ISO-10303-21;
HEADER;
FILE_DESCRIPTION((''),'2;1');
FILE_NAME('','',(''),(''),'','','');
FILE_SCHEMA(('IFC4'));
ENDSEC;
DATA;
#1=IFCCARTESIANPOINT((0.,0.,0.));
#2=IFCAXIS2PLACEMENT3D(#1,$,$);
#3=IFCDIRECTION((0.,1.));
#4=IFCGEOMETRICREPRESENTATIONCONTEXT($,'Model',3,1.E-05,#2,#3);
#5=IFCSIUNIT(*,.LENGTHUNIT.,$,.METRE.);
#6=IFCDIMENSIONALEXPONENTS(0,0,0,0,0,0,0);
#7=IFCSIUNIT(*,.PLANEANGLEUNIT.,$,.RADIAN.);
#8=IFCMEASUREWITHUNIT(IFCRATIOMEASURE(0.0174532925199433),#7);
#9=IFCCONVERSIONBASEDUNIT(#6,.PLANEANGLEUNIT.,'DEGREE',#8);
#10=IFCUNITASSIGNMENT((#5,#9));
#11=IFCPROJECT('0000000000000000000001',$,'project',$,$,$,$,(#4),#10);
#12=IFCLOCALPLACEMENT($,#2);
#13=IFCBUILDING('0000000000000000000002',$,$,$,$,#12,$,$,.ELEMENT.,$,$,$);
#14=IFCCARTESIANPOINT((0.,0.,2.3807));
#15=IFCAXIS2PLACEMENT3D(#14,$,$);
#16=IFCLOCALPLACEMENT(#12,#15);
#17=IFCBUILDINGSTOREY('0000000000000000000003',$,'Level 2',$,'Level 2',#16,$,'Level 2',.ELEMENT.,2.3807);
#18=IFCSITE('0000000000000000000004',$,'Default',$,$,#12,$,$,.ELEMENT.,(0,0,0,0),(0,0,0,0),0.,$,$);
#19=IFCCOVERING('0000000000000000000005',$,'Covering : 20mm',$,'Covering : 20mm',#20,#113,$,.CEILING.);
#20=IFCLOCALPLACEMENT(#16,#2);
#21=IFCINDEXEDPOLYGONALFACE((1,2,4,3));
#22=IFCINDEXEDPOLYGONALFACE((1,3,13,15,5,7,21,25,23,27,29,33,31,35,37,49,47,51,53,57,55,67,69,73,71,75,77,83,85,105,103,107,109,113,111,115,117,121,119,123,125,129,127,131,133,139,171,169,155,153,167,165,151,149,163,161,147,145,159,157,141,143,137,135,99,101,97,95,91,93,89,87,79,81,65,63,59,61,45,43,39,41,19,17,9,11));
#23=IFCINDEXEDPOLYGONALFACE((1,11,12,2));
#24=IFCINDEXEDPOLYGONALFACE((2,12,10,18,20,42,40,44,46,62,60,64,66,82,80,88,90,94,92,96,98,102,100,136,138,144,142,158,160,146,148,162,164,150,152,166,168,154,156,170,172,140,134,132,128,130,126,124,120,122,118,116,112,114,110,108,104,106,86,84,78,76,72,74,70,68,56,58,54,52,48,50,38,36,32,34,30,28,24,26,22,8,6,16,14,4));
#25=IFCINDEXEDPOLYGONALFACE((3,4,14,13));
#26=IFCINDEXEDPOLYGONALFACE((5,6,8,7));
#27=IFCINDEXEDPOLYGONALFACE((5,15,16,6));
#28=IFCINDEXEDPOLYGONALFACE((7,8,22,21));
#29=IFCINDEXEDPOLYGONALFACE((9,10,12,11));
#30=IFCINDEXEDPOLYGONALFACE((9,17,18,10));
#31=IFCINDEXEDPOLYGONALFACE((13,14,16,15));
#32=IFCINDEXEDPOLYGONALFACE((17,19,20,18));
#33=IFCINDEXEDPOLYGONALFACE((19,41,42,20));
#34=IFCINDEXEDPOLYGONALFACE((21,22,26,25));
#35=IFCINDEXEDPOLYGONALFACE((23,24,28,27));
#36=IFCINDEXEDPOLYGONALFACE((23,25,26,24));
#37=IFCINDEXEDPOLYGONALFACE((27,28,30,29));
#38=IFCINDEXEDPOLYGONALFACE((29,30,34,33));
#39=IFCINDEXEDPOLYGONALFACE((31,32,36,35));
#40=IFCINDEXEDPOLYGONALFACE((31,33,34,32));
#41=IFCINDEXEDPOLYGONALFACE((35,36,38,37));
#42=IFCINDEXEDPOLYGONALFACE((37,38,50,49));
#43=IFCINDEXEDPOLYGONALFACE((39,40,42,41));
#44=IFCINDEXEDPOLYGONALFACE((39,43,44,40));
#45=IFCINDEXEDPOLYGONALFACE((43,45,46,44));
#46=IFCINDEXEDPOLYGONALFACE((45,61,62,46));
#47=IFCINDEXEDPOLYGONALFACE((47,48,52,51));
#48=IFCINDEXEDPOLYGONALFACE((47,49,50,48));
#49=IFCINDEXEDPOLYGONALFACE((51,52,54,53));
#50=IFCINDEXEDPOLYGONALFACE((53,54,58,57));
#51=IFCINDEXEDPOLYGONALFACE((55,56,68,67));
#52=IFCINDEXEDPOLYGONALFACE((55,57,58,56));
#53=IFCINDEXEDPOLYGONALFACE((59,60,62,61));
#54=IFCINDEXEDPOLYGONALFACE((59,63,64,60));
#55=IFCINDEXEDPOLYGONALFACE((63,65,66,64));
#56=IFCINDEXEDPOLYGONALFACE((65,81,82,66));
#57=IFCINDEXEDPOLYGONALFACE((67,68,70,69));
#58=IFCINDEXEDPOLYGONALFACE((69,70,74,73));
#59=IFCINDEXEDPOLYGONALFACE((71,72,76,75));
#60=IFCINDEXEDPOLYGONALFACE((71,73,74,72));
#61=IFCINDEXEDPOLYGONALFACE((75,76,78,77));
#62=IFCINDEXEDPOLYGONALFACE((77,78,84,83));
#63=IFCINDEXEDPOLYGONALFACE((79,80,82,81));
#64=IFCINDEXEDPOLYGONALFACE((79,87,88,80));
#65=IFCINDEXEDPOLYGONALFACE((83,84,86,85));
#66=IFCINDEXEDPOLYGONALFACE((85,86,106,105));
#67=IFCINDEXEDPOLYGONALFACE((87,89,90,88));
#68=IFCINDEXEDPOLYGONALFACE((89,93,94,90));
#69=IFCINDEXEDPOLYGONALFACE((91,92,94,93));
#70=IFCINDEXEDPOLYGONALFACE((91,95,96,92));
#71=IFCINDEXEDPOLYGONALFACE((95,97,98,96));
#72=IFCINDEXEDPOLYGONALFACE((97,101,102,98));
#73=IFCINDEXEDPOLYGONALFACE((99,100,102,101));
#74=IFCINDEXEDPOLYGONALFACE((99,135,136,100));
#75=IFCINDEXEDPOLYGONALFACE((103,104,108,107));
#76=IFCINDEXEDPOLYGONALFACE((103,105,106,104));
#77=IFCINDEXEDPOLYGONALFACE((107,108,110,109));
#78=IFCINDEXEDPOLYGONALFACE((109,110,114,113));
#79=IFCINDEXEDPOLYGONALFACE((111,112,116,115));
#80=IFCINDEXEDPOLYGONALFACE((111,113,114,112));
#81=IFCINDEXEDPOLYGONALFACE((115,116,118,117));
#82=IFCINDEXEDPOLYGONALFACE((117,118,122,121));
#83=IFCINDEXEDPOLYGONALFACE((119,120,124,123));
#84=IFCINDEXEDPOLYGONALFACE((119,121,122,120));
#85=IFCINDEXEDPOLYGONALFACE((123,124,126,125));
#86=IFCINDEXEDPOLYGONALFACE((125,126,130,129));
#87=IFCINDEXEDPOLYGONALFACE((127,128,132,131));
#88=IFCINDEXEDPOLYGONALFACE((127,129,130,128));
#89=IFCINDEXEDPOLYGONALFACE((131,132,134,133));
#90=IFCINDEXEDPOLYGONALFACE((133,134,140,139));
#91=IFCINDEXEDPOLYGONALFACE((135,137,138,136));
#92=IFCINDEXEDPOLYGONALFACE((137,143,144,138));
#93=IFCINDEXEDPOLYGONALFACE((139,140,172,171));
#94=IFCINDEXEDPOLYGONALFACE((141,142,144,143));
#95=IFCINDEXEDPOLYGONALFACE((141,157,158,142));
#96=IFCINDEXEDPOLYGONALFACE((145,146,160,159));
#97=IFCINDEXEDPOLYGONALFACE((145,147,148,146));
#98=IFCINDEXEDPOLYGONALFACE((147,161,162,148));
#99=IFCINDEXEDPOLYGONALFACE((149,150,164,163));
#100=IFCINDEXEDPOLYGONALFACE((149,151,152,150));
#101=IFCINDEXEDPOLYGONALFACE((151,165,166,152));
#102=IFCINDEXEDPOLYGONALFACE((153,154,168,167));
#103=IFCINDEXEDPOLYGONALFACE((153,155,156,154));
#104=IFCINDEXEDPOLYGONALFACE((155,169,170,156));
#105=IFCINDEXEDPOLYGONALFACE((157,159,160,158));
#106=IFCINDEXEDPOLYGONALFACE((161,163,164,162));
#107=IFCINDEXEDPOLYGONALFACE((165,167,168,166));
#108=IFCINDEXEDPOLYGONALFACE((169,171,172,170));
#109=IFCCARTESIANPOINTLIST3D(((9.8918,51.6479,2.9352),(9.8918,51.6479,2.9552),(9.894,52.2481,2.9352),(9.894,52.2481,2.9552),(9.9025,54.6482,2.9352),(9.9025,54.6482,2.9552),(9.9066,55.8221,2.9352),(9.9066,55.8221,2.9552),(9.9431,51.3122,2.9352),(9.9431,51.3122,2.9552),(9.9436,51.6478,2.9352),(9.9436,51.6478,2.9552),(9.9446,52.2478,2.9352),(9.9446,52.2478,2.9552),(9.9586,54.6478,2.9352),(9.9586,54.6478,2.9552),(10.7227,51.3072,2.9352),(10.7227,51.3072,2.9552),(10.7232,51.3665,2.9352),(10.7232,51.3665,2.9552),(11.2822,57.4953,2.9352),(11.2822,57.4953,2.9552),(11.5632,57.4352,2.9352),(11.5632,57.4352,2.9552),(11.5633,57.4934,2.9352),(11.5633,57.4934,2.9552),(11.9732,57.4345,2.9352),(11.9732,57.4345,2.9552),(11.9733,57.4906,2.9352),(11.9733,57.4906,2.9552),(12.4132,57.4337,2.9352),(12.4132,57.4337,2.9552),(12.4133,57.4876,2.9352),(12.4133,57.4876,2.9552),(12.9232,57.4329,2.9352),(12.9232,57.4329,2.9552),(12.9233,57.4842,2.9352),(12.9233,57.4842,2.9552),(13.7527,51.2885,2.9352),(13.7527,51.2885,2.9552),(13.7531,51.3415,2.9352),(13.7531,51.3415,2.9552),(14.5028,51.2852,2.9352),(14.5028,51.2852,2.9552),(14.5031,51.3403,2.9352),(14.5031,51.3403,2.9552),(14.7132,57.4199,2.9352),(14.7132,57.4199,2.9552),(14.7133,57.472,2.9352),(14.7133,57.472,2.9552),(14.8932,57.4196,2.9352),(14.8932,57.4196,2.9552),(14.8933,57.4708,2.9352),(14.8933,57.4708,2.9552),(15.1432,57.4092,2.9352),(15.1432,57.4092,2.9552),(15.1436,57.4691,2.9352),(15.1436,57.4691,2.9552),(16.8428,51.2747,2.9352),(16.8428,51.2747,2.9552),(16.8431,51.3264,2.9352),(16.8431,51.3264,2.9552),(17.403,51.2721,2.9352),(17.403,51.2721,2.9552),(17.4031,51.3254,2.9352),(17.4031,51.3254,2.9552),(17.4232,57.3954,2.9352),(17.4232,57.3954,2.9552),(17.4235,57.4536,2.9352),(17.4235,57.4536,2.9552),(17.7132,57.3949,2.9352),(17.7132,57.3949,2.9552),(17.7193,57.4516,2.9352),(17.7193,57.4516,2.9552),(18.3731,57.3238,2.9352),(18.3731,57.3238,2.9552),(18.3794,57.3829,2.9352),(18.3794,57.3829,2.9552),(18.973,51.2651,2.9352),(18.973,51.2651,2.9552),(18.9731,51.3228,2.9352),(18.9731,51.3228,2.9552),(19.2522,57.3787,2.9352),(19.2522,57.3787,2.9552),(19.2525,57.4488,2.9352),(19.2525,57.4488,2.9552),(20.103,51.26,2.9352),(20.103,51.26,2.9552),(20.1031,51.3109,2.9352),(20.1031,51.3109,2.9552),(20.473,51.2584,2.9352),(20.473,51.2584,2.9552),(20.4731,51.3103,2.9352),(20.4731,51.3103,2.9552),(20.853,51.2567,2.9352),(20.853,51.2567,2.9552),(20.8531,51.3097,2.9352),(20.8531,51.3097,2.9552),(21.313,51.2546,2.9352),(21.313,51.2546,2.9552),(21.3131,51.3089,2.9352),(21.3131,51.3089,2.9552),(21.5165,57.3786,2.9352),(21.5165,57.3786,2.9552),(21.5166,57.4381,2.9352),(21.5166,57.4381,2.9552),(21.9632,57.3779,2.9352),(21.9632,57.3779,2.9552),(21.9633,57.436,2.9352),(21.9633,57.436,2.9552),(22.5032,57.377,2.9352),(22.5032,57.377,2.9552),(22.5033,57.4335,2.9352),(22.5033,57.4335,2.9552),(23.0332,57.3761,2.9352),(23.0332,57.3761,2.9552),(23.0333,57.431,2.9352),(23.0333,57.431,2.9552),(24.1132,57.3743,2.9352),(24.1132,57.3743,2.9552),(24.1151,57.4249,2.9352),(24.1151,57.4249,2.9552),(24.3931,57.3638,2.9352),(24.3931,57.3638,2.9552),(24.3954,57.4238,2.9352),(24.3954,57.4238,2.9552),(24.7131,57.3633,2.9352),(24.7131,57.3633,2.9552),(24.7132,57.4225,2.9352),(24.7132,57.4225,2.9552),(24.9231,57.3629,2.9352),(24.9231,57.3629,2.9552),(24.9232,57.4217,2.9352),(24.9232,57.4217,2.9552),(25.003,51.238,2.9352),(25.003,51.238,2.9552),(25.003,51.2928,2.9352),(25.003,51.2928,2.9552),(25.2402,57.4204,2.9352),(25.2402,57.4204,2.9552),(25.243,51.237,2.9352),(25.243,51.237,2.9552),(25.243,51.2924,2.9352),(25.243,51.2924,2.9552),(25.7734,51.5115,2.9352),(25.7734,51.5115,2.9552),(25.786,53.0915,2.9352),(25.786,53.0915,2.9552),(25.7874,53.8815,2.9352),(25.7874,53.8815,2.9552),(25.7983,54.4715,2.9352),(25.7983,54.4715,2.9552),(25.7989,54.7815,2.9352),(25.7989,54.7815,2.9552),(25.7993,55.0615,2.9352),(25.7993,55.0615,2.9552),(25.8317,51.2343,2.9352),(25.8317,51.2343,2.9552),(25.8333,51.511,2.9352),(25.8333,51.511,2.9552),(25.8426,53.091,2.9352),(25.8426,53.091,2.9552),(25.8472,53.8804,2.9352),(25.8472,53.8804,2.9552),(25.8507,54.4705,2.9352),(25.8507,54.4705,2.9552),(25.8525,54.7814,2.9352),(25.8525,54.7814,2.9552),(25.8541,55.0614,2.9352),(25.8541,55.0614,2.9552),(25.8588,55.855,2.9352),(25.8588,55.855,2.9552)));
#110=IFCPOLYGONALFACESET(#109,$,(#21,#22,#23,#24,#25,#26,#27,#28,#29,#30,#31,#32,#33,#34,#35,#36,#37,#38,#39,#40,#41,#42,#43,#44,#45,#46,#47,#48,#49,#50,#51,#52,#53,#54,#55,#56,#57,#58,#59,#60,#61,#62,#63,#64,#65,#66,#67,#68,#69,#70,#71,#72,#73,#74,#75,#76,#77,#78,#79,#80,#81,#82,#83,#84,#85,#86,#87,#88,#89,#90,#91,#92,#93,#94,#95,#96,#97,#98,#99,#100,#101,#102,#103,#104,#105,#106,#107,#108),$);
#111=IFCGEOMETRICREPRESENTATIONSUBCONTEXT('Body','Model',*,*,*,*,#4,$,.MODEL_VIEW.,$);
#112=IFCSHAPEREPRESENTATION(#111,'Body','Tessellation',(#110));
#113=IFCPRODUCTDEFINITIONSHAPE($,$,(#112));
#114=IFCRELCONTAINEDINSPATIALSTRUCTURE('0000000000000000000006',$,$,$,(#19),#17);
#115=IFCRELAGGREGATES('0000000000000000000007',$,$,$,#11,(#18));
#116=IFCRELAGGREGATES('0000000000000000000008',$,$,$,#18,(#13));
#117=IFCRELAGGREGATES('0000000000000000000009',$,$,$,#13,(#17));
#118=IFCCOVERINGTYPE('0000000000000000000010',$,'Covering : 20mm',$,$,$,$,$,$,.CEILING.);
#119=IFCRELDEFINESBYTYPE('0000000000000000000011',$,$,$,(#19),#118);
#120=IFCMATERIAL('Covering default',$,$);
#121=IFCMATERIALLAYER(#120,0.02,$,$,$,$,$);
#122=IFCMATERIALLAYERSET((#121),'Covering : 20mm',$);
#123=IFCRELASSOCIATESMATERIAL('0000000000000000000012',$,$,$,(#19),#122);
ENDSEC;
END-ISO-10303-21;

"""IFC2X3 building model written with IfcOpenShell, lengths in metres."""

from ifc_helpers import new_model, entity, si_unit, converted_unit, direction, frame, origin, origin_with_axes, place, context, subcontext, project, spatial, polyline, outline, extrude, material, layer, layer_set, layer_usage, type_object, element, save


model = new_model("IFC2X3")

# Units and contexts
model_context = context("Model", 3, precision=1e-05, world=origin(), true_north=direction((0.0, 1.0)))
body_context = subcontext(model_context, "Body", "Model", "MODEL_VIEW")
ifc_project = project(units=[si_unit("LENGTHUNIT", "METRE"), converted_unit("PLANEANGLEUNIT", "DEGREE", entity("IfcRatioMeasure", 0.0174532925199433), si_unit("PLANEANGLEUNIT", "RADIAN"), dimensions=[0, 0, 0, 0, 0, 0, 0])], contexts=[model_context])

# Site, building, storey
placement = place(None, origin())
site = spatial("IfcSite", under=ifc_project, at=placement, Name="Default", CompositionType="ELEMENT", RefLatitude=(0, 0, 0, 0), RefLongitude=(0, 0, 0, 0), RefElevation=0.0)
building = spatial("IfcBuilding", under=site, at=placement, CompositionType="ELEMENT")
storey_placement = place(placement, frame((0.0, 0.0, 2.3807)))
storey = spatial("IfcBuildingStorey", under=building, at=storey_placement, Name="Level 2", ObjectType="Level 2", LongName="Level 2", CompositionType="ELEMENT", Elevation=2.3807)

# Covering
ifc_material_1 = material(Name="Covering default")
ifc_layer_1 = layer(ifc_material_1, 0.02)
ifc_layer_set_1 = layer_set([ifc_layer_1], Name="Covering : 20mm")
ifc_layer_usage_1 = layer_usage(ifc_layer_set_1, "AXIS3", "POSITIVE", 0.0)
covering_type_1 = type_object("IfcCoveringType", Name="Covering : 20mm", PredefinedType="CEILING")
covering_1_placement = place(placement, frame((0.0, 0.0, 5.3159)))
element("IfcCovering", 1, at=covering_1_placement, inside=storey, type_object=covering_type_1, material=ifc_layer_usage_1, Name="Covering : 20mm", ObjectType="Covering : 20mm", PredefinedType="CEILING", context=body_context, shape_type="SweptSolid", body=[
    extrude(outline(polyline([(9.894, 52.2481), (9.9446, 52.2478), (9.9586, 54.6478), (9.9025, 54.6482), (9.9066, 55.8221), (11.2822, 57.4953), (11.5633, 57.4934), (11.5632, 57.4352), (11.9732, 57.4345), (11.9733, 57.4906), (12.4133, 57.4876), (12.4132, 57.4337), (12.9232, 57.4329), (12.9233, 57.4842), (14.7133, 57.472), (14.7132, 57.4199), (14.8932, 57.4196), (14.8933, 57.4708), (15.1436, 57.4691), (15.1432, 57.4092), (17.4232, 57.3954), (17.4235, 57.4536), (17.7193, 57.4516), (17.7132, 57.3949), (18.3731, 57.3238), (18.3794, 57.3829), (19.2522, 57.3787), (19.2525, 57.4488), (21.5166, 57.4381), (21.5165, 57.3786), (21.9632, 57.3779), (21.9633, 57.436), (22.5033, 57.4335), (22.5032, 57.377), (23.0332, 57.3761), (23.0333, 57.431), (24.1151, 57.4249), (24.1132, 57.3743), (24.3931, 57.3638), (24.3954, 57.4238), (24.7132, 57.4225), (24.7131, 57.3633), (24.9231, 57.3629), (24.9232, 57.4217), (25.2402, 57.4204), (25.8588, 55.855), (25.8541, 55.0614), (25.7993, 55.0615), (25.7989, 54.7815), (25.8525, 54.7814), (25.8507, 54.4705), (25.7983, 54.4715), (25.7874, 53.8815), (25.8472, 53.8804), (25.8426, 53.091), (25.786, 53.0915), (25.7734, 51.5115), (25.8333, 51.511), (25.8317, 51.2343), (25.243, 51.237), (25.243, 51.2924), (25.003, 51.2928), (25.003, 51.238), (21.313, 51.2546), (21.3131, 51.3089), (20.8531, 51.3097), (20.853, 51.2567), (20.473, 51.2584), (20.4731, 51.3103), (20.1031, 51.3109), (20.103, 51.26), (18.973, 51.2651), (18.9731, 51.3228), (17.4031, 51.3254), (17.403, 51.2721), (16.8428, 51.2747), (16.8431, 51.3264), (14.5031, 51.3403), (14.5028, 51.2852), (13.7527, 51.2885), (13.7531, 51.3415), (10.7232, 51.3665), (10.7227, 51.3072), (9.9431, 51.3122), (9.9436, 51.6478), (9.8918, 51.6479), (9.894, 52.2481)])), origin_with_axes(), (0.0, 0.0, 1.0), 0.02),
])

save(model, "model.ifc")
